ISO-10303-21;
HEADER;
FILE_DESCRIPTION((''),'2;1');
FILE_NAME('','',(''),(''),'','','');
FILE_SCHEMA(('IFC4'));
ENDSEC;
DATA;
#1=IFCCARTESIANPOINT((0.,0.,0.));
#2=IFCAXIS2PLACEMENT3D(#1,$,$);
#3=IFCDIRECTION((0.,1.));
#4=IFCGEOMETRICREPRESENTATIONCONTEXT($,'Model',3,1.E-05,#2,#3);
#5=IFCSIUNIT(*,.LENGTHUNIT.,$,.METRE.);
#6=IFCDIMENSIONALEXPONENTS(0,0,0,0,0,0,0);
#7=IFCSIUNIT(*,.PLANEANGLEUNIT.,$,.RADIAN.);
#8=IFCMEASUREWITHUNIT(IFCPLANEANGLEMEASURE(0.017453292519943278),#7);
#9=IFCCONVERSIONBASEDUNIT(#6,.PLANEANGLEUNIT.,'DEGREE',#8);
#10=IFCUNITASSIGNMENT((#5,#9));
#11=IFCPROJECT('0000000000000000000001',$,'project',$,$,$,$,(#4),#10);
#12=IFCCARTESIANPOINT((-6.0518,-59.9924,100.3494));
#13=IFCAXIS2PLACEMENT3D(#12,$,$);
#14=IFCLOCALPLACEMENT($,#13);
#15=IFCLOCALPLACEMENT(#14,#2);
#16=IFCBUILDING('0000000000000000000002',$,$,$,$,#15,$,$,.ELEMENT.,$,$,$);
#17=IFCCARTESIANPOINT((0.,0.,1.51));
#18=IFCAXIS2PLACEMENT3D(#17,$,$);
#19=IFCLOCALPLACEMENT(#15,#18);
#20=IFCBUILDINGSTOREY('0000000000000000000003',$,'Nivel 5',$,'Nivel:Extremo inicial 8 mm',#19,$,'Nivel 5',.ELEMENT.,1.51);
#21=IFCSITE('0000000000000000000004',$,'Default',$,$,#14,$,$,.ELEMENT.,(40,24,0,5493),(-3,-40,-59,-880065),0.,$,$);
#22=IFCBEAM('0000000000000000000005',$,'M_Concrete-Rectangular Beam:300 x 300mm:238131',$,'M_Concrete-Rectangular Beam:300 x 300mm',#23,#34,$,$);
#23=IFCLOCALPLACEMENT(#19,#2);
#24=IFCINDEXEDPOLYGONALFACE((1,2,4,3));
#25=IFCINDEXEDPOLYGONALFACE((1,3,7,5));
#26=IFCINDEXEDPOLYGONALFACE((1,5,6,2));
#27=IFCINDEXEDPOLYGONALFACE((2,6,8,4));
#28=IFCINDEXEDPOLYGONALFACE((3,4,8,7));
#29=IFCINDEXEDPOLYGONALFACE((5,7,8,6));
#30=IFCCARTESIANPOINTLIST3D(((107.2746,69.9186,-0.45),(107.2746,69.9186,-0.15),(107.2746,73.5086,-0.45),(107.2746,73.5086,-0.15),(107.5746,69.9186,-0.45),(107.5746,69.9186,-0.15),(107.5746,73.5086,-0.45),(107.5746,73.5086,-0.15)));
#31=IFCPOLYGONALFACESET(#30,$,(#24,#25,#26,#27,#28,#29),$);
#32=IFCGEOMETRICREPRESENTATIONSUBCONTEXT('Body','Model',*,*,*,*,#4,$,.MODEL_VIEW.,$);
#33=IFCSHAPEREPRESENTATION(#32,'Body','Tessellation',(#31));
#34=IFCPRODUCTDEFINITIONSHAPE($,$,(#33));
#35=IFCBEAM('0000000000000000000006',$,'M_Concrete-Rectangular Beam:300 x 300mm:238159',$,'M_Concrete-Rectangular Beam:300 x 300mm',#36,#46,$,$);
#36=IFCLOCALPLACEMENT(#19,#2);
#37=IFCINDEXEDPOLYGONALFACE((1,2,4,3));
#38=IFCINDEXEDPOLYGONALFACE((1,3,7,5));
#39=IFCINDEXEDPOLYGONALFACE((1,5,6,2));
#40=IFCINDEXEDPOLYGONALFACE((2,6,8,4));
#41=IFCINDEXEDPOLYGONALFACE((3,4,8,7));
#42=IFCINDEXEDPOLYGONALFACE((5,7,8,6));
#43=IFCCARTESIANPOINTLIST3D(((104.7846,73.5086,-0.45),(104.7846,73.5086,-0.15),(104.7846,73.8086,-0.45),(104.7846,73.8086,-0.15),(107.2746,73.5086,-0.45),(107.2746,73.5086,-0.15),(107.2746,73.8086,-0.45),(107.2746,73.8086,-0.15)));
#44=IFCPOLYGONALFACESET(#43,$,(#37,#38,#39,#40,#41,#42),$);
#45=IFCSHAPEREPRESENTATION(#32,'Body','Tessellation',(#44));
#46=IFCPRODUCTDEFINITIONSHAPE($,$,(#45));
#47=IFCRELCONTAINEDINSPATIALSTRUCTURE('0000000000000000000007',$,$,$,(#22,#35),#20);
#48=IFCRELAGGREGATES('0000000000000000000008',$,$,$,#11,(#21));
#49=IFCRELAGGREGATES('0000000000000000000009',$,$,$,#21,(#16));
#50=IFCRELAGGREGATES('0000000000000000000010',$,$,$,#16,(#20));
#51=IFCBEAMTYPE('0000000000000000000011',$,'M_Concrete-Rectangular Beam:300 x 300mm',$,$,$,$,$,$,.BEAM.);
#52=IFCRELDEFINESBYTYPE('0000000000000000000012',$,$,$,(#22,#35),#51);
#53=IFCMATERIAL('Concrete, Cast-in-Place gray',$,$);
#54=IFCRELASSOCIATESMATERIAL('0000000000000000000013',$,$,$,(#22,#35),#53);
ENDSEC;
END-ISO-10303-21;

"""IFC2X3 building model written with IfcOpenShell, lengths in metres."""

from ifc_helpers import new_model, entity, si_unit, converted_unit, direction, frame, origin, origin_2d_with_axis, place, context, subcontext, project, spatial, rectangle, extrude, material, type_object, element, save


model = new_model("IFC2X3")

# Units and contexts
model_context = context("Model", 3, precision=1e-05, world=origin(), true_north=direction((0.0, 1.0)))
body_context = subcontext(model_context, "Body", "Model", "MODEL_VIEW")
ifc_project = project(units=[si_unit("LENGTHUNIT", "METRE"), converted_unit("PLANEANGLEUNIT", "DEGREE", entity("IfcPlaneAngleMeasure", 0.017453292519943278), si_unit("PLANEANGLEUNIT", "RADIAN"), dimensions=[0, 0, 0, 0, 0, 0, 0])], contexts=[model_context])

# Site, building, storey
site_placement = place(None, frame((-6.0518, -59.9924, 100.3494)))
site = spatial("IfcSite", under=ifc_project, at=site_placement, Name="Default", CompositionType="ELEMENT", RefLatitude=(40, 24, 0, 5493), RefLongitude=(-3, -40, -59, -880065), RefElevation=0.0)
building_placement = place(site_placement, origin())
building = spatial("IfcBuilding", under=site, at=building_placement, CompositionType="ELEMENT")
storey_placement = place(building_placement, frame((0.0, 0.0, 1.51)))
storey = spatial("IfcBuildingStorey", under=building, at=storey_placement, Name="Nivel 5", ObjectType="Nivel:Extremo inicial 8 mm", LongName="Nivel 5", CompositionType="ELEMENT", Elevation=1.51)

# Beams
ifc_material_1 = material(Name="Concrete, Cast-in-Place gray")
beam_type = type_object("IfcBeamType", Name="M_Concrete-Rectangular Beam:300 x 300mm", PredefinedType="BEAM")
beam_1_placement = place(storey_placement, frame((107.4246, 69.7686, 0.0), z_axis=(0.0, 0.0, 1.0), x_axis=(0.0, 1.0, 0.0)))
element("IfcBeam", 1, at=beam_1_placement, inside=storey, type_object=beam_type, material=ifc_material_1, Name="M_Concrete-Rectangular Beam:300 x 300mm:238131", ObjectType="M_Concrete-Rectangular Beam:300 x 300mm", context=body_context, shape_type="SweptSolid", body=[
    extrude(rectangle(XDim=0.3, YDim=0.3, at=origin_2d_with_axis()), frame((0.15, 0.0, -0.3), z_axis=(1.0, 0.0, 0.0), x_axis=(0.0, 0.0, -1.0)), (0.0, 0.0, 1.0), 3.59),
])
beam_2_placement = place(storey_placement, frame((107.4246, 73.6586, 0.0), z_axis=(0.0, 0.0, 1.0), x_axis=(-1.0, 0.0, 0.0)))
element("IfcBeam", 2, at=beam_2_placement, inside=storey, type_object=beam_type, material=ifc_material_1, Name="M_Concrete-Rectangular Beam:300 x 300mm:238159", ObjectType="M_Concrete-Rectangular Beam:300 x 300mm", context=body_context, shape_type="SweptSolid", body=[
    extrude(rectangle(XDim=0.3, YDim=0.3, at=origin_2d_with_axis()), frame((0.15, 0.0, -0.3), z_axis=(1.0, 0.0, 0.0), x_axis=(0.0, 0.0, -1.0)), (0.0, 0.0, 1.0), 2.49),
])

save(model, "model.ifc")
